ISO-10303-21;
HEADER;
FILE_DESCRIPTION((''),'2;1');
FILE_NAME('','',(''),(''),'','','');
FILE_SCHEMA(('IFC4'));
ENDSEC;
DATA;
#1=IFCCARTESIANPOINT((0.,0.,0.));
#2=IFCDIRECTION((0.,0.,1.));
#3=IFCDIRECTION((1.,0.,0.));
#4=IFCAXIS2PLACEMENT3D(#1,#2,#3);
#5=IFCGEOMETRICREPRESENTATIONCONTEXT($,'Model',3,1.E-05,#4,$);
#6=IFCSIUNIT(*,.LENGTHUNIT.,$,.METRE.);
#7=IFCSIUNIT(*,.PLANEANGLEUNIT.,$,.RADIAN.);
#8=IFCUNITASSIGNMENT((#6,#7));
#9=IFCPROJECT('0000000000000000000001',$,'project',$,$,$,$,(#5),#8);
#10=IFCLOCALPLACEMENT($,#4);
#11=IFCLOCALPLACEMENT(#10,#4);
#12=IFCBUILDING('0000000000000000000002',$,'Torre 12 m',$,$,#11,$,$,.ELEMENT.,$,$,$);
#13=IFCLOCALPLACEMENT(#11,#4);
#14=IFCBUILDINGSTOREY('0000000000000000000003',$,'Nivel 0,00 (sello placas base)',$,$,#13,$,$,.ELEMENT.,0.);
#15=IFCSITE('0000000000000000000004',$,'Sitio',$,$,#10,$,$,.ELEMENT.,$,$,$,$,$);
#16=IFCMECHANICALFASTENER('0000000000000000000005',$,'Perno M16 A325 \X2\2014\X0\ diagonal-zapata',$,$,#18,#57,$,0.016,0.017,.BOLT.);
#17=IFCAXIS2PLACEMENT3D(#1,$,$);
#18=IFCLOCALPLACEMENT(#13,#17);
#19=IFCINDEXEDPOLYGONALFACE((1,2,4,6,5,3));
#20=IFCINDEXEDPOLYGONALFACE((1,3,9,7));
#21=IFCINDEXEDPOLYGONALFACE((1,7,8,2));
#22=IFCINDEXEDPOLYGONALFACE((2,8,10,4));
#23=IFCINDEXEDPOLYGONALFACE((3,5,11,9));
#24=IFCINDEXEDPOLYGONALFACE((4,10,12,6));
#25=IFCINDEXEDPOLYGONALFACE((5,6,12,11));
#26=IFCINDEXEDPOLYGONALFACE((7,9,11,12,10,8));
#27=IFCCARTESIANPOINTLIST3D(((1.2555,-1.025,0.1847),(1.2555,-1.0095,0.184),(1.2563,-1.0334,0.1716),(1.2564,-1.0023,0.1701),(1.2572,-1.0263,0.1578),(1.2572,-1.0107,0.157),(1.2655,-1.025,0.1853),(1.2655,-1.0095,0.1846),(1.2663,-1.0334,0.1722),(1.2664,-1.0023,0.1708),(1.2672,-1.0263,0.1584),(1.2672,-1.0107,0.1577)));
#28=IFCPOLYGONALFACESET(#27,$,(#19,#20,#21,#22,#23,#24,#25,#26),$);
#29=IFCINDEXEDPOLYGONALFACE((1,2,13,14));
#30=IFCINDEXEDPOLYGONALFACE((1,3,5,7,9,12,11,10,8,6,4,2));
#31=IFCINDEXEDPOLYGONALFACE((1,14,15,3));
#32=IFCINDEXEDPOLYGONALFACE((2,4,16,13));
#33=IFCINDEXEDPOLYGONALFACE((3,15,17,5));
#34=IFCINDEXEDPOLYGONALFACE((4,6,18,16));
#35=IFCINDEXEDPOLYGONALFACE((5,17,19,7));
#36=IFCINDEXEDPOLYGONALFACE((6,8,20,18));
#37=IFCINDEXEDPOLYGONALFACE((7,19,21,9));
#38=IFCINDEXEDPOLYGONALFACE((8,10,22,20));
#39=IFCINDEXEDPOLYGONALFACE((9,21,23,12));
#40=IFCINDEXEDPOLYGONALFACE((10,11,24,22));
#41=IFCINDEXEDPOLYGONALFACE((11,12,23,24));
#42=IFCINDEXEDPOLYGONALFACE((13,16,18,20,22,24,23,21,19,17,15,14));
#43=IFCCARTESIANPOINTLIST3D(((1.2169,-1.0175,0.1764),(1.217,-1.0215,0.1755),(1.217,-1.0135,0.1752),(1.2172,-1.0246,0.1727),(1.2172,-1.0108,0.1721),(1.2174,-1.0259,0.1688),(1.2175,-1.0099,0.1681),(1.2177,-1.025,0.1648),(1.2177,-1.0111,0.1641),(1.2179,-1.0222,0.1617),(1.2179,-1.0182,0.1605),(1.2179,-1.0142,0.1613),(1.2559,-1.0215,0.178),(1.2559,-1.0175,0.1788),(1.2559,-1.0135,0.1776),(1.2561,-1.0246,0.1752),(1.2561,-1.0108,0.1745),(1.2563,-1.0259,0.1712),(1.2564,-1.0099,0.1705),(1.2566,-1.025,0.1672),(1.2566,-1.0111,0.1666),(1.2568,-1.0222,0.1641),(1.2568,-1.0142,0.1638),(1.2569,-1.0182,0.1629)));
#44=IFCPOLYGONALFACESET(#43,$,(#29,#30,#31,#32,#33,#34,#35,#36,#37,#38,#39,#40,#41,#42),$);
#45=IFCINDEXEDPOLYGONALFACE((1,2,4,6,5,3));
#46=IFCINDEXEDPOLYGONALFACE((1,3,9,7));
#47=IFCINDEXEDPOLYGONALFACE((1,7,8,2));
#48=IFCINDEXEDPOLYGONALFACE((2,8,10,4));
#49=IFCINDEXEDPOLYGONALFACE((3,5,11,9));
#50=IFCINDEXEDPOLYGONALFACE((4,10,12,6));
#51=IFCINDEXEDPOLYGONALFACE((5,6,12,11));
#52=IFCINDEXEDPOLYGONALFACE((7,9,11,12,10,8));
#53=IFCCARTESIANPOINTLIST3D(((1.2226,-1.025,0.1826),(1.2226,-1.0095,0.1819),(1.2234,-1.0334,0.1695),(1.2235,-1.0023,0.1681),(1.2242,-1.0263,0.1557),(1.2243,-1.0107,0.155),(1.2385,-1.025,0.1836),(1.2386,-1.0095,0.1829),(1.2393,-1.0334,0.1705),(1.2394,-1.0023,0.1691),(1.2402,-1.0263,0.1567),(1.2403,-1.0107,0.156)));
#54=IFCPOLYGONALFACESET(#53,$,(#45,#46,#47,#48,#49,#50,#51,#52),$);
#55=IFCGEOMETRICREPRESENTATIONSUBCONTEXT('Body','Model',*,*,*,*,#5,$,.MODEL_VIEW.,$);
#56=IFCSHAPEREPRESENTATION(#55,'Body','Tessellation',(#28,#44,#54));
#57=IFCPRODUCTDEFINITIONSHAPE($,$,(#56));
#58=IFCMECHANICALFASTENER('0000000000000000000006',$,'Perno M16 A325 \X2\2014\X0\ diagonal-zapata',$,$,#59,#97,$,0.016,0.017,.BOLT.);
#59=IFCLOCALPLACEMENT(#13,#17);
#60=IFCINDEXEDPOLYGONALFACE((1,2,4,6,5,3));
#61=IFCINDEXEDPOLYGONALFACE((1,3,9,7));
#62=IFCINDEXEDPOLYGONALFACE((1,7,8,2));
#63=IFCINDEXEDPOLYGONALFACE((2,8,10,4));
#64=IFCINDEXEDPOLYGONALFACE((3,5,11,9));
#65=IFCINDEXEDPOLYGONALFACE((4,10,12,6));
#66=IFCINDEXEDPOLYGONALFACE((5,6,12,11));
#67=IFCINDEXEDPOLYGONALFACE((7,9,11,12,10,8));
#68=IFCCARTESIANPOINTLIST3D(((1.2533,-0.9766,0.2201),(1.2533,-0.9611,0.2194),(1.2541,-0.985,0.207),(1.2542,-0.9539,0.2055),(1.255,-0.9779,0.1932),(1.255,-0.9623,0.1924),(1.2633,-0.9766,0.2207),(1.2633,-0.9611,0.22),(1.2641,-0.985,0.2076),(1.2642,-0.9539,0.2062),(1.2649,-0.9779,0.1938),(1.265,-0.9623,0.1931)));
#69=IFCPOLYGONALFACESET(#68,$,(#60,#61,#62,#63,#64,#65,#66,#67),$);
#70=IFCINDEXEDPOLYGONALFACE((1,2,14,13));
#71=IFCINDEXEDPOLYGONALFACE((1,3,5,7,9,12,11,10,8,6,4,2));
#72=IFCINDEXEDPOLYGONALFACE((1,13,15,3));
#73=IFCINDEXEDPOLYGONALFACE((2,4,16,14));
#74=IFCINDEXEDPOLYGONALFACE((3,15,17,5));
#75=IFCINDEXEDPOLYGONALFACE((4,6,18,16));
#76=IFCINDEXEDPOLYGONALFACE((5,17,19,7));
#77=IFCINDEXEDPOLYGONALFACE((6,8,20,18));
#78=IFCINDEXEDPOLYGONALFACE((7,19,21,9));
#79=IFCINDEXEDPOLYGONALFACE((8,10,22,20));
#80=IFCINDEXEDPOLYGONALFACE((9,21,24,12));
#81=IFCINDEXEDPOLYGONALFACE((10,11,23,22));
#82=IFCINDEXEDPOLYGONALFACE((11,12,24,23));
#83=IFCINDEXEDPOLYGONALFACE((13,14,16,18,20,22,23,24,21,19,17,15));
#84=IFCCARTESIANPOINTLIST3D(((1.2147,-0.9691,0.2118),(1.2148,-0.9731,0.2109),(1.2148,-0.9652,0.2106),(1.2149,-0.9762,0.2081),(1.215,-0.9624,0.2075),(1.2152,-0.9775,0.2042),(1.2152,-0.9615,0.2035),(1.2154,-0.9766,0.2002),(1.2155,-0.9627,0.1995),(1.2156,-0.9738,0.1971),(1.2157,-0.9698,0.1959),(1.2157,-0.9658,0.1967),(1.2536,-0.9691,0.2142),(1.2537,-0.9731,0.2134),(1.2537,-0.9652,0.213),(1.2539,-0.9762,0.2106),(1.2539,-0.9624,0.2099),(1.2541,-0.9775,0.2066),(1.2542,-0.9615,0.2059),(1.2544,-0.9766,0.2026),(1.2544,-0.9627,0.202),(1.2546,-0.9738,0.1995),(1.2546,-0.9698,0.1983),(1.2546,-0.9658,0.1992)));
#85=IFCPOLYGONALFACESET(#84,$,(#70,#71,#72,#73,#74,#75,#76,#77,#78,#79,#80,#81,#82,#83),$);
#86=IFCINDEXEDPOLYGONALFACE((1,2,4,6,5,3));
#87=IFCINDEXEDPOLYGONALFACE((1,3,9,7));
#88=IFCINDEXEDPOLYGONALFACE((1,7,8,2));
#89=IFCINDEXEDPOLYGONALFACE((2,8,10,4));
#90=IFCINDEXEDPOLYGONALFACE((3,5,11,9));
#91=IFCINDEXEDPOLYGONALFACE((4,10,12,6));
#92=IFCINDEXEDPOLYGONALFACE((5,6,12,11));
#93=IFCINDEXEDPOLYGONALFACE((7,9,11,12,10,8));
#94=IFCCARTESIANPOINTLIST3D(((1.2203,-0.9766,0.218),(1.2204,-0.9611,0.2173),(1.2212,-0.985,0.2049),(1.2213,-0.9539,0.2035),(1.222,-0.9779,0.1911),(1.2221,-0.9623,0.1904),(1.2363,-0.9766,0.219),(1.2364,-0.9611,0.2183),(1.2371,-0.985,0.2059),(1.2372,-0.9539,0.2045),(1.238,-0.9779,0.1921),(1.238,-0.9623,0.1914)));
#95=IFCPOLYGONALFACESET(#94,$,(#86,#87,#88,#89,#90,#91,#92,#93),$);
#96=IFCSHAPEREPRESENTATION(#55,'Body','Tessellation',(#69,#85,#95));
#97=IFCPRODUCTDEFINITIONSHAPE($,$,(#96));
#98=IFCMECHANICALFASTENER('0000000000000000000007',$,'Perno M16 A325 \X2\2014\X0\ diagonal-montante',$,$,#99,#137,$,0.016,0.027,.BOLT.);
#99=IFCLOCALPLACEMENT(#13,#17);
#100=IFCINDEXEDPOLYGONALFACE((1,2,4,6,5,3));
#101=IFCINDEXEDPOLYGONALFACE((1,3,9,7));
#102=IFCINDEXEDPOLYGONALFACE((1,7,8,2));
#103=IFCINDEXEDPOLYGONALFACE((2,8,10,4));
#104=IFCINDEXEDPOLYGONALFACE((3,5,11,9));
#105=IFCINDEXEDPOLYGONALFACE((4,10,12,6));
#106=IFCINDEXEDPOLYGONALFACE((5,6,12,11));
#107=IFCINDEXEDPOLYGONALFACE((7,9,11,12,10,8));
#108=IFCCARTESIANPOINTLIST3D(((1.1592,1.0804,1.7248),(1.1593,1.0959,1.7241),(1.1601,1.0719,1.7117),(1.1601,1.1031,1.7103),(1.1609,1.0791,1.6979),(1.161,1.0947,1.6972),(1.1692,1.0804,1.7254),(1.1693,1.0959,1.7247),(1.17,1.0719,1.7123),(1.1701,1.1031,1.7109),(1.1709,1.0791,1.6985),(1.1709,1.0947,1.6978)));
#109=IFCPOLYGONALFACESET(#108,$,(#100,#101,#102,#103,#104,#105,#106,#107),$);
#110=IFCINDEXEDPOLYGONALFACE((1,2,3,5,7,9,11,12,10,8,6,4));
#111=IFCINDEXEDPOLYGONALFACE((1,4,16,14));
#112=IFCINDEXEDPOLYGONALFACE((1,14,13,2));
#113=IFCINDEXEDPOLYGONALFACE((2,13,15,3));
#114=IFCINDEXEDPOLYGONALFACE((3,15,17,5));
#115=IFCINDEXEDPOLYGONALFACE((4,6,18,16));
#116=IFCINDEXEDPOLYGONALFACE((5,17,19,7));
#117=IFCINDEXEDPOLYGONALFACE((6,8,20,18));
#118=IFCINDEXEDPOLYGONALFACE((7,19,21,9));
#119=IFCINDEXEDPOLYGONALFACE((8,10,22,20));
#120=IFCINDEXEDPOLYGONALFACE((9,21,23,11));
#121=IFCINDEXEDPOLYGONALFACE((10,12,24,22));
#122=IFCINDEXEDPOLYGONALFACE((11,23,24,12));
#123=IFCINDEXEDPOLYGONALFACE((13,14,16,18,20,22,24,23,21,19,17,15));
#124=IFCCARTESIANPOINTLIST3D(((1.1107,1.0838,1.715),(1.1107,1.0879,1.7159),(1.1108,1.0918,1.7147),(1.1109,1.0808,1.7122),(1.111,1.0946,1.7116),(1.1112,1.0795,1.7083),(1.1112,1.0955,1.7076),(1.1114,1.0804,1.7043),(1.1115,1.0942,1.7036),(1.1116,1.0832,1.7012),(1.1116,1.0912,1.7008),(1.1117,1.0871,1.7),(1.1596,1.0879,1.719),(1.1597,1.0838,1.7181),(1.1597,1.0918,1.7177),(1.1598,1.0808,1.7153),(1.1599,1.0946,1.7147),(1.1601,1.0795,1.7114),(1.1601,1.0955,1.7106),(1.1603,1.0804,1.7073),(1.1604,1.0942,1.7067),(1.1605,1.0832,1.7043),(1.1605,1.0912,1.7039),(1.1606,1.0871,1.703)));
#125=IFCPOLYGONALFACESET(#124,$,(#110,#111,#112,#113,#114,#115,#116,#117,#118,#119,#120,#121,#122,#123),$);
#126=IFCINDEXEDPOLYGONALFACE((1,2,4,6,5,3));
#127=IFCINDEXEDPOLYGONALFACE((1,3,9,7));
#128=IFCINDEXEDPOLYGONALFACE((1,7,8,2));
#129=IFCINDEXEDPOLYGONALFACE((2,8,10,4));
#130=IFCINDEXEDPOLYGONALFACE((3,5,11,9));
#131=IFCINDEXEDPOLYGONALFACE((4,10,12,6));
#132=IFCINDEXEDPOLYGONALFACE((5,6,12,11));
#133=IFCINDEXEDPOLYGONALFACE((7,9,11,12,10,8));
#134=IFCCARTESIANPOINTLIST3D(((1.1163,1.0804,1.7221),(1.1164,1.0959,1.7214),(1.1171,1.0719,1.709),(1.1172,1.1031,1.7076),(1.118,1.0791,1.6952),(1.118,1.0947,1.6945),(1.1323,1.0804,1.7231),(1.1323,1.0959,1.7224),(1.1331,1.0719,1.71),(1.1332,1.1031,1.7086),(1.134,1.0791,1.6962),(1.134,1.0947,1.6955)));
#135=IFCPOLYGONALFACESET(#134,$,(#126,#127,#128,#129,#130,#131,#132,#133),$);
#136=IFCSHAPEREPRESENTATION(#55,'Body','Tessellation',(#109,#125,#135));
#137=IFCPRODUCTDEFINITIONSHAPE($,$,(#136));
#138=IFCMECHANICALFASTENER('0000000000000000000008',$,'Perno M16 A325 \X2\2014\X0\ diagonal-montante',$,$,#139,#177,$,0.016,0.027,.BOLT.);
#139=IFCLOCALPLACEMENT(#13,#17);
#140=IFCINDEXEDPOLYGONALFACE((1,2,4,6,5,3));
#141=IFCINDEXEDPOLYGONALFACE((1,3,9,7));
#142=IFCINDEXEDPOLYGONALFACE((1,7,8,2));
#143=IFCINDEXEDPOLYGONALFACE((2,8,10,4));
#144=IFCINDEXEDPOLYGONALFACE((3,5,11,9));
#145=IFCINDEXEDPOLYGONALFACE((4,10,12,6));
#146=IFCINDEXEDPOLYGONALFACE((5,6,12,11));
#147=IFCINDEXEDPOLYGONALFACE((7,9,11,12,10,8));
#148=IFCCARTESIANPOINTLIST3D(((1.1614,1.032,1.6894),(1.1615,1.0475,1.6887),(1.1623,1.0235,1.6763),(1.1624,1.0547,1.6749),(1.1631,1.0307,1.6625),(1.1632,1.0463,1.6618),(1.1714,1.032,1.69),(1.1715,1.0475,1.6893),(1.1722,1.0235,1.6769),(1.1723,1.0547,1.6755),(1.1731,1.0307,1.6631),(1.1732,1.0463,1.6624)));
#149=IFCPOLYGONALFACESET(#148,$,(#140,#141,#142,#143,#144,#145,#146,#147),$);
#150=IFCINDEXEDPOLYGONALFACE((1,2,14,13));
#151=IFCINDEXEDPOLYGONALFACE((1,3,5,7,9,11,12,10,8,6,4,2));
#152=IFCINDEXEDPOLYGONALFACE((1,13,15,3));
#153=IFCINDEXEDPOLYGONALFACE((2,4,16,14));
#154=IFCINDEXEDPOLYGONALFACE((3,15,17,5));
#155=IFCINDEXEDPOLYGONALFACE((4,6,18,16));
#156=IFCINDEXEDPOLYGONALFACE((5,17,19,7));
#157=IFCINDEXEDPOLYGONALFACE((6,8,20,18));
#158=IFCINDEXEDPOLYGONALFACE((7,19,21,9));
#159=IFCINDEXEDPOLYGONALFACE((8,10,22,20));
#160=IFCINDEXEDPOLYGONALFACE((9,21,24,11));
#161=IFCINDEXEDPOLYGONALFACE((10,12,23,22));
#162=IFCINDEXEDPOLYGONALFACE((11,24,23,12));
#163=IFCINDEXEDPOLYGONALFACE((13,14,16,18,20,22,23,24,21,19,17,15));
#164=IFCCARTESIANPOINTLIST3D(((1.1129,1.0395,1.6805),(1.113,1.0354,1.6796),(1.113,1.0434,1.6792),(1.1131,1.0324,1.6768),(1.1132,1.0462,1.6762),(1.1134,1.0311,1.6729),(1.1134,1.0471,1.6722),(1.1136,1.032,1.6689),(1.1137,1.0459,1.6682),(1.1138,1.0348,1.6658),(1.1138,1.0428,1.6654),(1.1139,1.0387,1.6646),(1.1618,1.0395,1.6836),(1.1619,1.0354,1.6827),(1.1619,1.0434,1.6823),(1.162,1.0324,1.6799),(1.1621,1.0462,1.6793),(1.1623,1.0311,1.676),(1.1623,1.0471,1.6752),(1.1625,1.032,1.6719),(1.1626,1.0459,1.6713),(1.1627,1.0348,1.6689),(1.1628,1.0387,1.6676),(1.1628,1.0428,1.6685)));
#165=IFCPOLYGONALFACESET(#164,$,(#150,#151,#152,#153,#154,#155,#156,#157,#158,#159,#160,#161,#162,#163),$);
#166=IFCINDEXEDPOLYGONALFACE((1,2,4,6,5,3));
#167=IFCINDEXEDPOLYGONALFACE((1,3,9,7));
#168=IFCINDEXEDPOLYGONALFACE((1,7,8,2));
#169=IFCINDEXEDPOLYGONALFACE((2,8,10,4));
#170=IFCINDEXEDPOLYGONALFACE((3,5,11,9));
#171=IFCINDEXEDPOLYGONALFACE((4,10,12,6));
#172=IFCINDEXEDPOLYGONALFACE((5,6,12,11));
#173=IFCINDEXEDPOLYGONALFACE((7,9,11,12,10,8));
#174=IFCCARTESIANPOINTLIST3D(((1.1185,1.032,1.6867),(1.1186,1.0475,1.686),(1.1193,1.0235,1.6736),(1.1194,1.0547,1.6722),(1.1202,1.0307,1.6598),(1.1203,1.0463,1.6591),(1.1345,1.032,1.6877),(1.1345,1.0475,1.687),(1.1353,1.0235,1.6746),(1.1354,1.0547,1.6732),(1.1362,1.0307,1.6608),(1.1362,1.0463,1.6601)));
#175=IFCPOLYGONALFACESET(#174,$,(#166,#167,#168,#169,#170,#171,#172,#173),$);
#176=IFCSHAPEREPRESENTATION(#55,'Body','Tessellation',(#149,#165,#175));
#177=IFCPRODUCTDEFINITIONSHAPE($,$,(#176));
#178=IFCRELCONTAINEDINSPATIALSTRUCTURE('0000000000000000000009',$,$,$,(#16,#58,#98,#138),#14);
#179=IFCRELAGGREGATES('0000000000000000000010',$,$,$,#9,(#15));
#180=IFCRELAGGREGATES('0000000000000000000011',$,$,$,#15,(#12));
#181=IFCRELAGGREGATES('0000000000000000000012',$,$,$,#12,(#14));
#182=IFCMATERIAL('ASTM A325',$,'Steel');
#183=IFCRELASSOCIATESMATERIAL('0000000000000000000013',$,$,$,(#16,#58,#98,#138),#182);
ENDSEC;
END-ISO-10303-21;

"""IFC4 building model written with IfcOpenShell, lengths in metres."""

from ifc_helpers import new_model, si_unit, frame, origin_with_axes, place, context, subcontext, project, spatial, polyline, outline, extrude, material, element, save


model = new_model("IFC4")

# Units and contexts
model_context = context("Model", 3, precision=1e-05, world=origin_with_axes())
body_context = subcontext(model_context, "Body", "Model", "MODEL_VIEW")
ifc_project = project(units=[si_unit("LENGTHUNIT", "METRE"), si_unit("PLANEANGLEUNIT", "RADIAN")], contexts=[model_context])

# Site, building, storey
site_placement = place(None, origin_with_axes())
site = spatial("IfcSite", under=ifc_project, at=site_placement, Name="Sitio", CompositionType="ELEMENT")
building_placement = place(site_placement, origin_with_axes())
building = spatial("IfcBuilding", under=site, at=building_placement, Name="Torre 12 m", CompositionType="ELEMENT")
storey_placement = place(building_placement, origin_with_axes())
storey = spatial("IfcBuildingStorey", under=building, at=storey_placement, Name="Nivel 0,00 (sello placas base)", CompositionType="ELEMENT", Elevation=0.0)

# Shared definitions
placement = place(storey_placement, origin_with_axes())

# Mechanical fasteners
ifc_material_1 = material(Name="ASTM A325", Category="Steel")
element("IfcMechanicalFastener", 1, at=placement, inside=storey, material=ifc_material_1, Name="Perno M16 A325 — diagonal-zapata", NominalDiameter=0.016, NominalLength=0.017, PredefinedType="BOLT", context=body_context, shape_type="SweptSolid", body=[
    extrude(outline(polyline([(0.0135, 0.0078), (0.0, 0.0156), (-0.0135, 0.0078), (-0.0135, -0.0078), (0.0, -0.0156), (0.0135, -0.0078), (0.0135, 0.0078)])), frame((1.2663, -1.0179, 0.1715), z_axis=(-0.998053, 0.0, -0.062378), x_axis=(0.033672, 0.841794, -0.538748)), (0.0, 0.0, 1.0), 0.01),
    extrude(outline(polyline([(0.008, 0.0), (0.0069, 0.004), (0.004, 0.0069), (0.0, 0.008), (-0.004, 0.0069), (-0.0069, 0.004), (-0.008, 0.0), (-0.0069, -0.004), (-0.004, -0.0069), (0.0, -0.008), (0.004, -0.0069), (0.0069, -0.004), (0.008, 0.0)])), frame((1.2564, -1.0179, 0.1709), z_axis=(-0.998053, 0.0, -0.062378), x_axis=(0.033672, 0.841794, -0.538748)), (0.0, 0.0, 1.0), 0.039),
    extrude(outline(polyline([(0.0135, 0.0078), (0.0, 0.0156), (-0.0135, 0.0078), (-0.0135, -0.0078), (0.0, -0.0156), (0.0135, -0.0078), (0.0135, 0.0078)])), frame((1.2394, -1.0179, 0.1698), z_axis=(-0.998053, 0.0, -0.062378), x_axis=(0.033672, 0.841794, -0.538748)), (0.0, 0.0, 1.0), 0.016),
])
element("IfcMechanicalFastener", 2, at=placement, inside=storey, material=ifc_material_1, Name="Perno M16 A325 — diagonal-zapata", NominalDiameter=0.016, NominalLength=0.017, PredefinedType="BOLT", context=body_context, shape_type="SweptSolid", body=[
    extrude(outline(polyline([(0.0135, 0.0078), (0.0, 0.0156), (-0.0135, 0.0078), (-0.0135, -0.0078), (0.0, -0.0156), (0.0135, -0.0078), (0.0135, 0.0078)])), frame((1.2641, -0.9695, 0.2069), z_axis=(-0.998053, 0.0, -0.062378), x_axis=(0.033672, 0.841794, -0.538748)), (0.0, 0.0, 1.0), 0.01),
    extrude(outline(polyline([(0.008, 0.0), (0.0069, 0.004), (0.004, 0.0069), (0.0, 0.008), (-0.004, 0.0069), (-0.0069, 0.004), (-0.008, 0.0), (-0.0069, -0.004), (-0.004, -0.0069), (0.0, -0.008), (0.004, -0.0069), (0.0069, -0.004), (0.008, 0.0)])), frame((1.2541, -0.9695, 0.2063), z_axis=(-0.998053, 0.0, -0.062378), x_axis=(0.033672, 0.841794, -0.538748)), (0.0, 0.0, 1.0), 0.039),
    extrude(outline(polyline([(0.0135, 0.0078), (0.0, 0.0156), (-0.0135, 0.0078), (-0.0135, -0.0078), (0.0, -0.0156), (0.0135, -0.0078), (0.0135, 0.0078)])), frame((1.2372, -0.9695, 0.2052), z_axis=(-0.998053, 0.0, -0.062378), x_axis=(0.033672, 0.841794, -0.538748)), (0.0, 0.0, 1.0), 0.016),
])
element("IfcMechanicalFastener", 3, at=placement, inside=storey, material=ifc_material_1, Name="Perno M16 A325 — diagonal-montante", NominalDiameter=0.016, NominalLength=0.027, PredefinedType="BOLT", context=body_context, shape_type="SweptSolid", body=[
    extrude(outline(polyline([(0.0135, 0.0078), (0.0, 0.0156), (-0.0135, 0.0078), (-0.0135, -0.0078), (0.0, -0.0156), (0.0135, -0.0078), (0.0135, 0.0078)])), frame((1.1701, 1.0875, 1.7116), z_axis=(-0.998053, 0.0, -0.062378), x_axis=(0.033672, 0.841794, -0.538748)), (0.0, 0.0, 1.0), 0.01),
    extrude(outline(polyline([(0.008, 0.0), (0.0069, 0.004), (0.004, 0.0069), (0.0, 0.008), (-0.004, 0.0069), (-0.0069, 0.004), (-0.008, 0.0), (-0.0069, -0.004), (-0.004, -0.0069), (0.0, -0.008), (0.004, -0.0069), (0.0069, -0.004), (0.008, 0.0)])), frame((1.1601, 1.0875, 1.711), z_axis=(-0.998053, 0.0, -0.062378), x_axis=(0.033672, 0.841794, -0.538748)), (0.0, 0.0, 1.0), 0.049),
    extrude(outline(polyline([(0.0135, 0.0078), (0.0, 0.0156), (-0.0135, 0.0078), (-0.0135, -0.0078), (0.0, -0.0156), (0.0135, -0.0078), (0.0135, 0.0078)])), frame((1.1331, 1.0875, 1.7093), z_axis=(-0.998053, 0.0, -0.062378), x_axis=(0.033672, 0.841794, -0.538748)), (0.0, 0.0, 1.0), 0.016),
])
element("IfcMechanicalFastener", 4, at=placement, inside=storey, material=ifc_material_1, Name="Perno M16 A325 — diagonal-montante", NominalDiameter=0.016, NominalLength=0.027, PredefinedType="BOLT", context=body_context, shape_type="SweptSolid", body=[
    extrude(outline(polyline([(0.0135, 0.0078), (0.0, 0.0156), (-0.0135, 0.0078), (-0.0135, -0.0078), (0.0, -0.0156), (0.0135, -0.0078), (0.0135, 0.0078)])), frame((1.1723, 1.0391, 1.6762), z_axis=(-0.998053, 0.0, -0.062378), x_axis=(0.033672, 0.841794, -0.538748)), (0.0, 0.0, 1.0), 0.01),
    extrude(outline(polyline([(0.008, 0.0), (0.0069, 0.004), (0.004, 0.0069), (0.0, 0.008), (-0.004, 0.0069), (-0.0069, 0.004), (-0.008, 0.0), (-0.0069, -0.004), (-0.004, -0.0069), (0.0, -0.008), (0.004, -0.0069), (0.0069, -0.004), (0.008, 0.0)])), frame((1.1623, 1.0391, 1.6756), z_axis=(-0.998053, 0.0, -0.062378), x_axis=(0.033672, 0.841794, -0.538748)), (0.0, 0.0, 1.0), 0.049),
    extrude(outline(polyline([(0.0135, 0.0078), (0.0, 0.0156), (-0.0135, 0.0078), (-0.0135, -0.0078), (0.0, -0.0156), (0.0135, -0.0078), (0.0135, 0.0078)])), frame((1.1354, 1.0391, 1.6739), z_axis=(-0.998053, 0.0, -0.062378), x_axis=(0.033672, 0.841794, -0.538748)), (0.0, 0.0, 1.0), 0.016),
])

save(model, "model.ifc")
